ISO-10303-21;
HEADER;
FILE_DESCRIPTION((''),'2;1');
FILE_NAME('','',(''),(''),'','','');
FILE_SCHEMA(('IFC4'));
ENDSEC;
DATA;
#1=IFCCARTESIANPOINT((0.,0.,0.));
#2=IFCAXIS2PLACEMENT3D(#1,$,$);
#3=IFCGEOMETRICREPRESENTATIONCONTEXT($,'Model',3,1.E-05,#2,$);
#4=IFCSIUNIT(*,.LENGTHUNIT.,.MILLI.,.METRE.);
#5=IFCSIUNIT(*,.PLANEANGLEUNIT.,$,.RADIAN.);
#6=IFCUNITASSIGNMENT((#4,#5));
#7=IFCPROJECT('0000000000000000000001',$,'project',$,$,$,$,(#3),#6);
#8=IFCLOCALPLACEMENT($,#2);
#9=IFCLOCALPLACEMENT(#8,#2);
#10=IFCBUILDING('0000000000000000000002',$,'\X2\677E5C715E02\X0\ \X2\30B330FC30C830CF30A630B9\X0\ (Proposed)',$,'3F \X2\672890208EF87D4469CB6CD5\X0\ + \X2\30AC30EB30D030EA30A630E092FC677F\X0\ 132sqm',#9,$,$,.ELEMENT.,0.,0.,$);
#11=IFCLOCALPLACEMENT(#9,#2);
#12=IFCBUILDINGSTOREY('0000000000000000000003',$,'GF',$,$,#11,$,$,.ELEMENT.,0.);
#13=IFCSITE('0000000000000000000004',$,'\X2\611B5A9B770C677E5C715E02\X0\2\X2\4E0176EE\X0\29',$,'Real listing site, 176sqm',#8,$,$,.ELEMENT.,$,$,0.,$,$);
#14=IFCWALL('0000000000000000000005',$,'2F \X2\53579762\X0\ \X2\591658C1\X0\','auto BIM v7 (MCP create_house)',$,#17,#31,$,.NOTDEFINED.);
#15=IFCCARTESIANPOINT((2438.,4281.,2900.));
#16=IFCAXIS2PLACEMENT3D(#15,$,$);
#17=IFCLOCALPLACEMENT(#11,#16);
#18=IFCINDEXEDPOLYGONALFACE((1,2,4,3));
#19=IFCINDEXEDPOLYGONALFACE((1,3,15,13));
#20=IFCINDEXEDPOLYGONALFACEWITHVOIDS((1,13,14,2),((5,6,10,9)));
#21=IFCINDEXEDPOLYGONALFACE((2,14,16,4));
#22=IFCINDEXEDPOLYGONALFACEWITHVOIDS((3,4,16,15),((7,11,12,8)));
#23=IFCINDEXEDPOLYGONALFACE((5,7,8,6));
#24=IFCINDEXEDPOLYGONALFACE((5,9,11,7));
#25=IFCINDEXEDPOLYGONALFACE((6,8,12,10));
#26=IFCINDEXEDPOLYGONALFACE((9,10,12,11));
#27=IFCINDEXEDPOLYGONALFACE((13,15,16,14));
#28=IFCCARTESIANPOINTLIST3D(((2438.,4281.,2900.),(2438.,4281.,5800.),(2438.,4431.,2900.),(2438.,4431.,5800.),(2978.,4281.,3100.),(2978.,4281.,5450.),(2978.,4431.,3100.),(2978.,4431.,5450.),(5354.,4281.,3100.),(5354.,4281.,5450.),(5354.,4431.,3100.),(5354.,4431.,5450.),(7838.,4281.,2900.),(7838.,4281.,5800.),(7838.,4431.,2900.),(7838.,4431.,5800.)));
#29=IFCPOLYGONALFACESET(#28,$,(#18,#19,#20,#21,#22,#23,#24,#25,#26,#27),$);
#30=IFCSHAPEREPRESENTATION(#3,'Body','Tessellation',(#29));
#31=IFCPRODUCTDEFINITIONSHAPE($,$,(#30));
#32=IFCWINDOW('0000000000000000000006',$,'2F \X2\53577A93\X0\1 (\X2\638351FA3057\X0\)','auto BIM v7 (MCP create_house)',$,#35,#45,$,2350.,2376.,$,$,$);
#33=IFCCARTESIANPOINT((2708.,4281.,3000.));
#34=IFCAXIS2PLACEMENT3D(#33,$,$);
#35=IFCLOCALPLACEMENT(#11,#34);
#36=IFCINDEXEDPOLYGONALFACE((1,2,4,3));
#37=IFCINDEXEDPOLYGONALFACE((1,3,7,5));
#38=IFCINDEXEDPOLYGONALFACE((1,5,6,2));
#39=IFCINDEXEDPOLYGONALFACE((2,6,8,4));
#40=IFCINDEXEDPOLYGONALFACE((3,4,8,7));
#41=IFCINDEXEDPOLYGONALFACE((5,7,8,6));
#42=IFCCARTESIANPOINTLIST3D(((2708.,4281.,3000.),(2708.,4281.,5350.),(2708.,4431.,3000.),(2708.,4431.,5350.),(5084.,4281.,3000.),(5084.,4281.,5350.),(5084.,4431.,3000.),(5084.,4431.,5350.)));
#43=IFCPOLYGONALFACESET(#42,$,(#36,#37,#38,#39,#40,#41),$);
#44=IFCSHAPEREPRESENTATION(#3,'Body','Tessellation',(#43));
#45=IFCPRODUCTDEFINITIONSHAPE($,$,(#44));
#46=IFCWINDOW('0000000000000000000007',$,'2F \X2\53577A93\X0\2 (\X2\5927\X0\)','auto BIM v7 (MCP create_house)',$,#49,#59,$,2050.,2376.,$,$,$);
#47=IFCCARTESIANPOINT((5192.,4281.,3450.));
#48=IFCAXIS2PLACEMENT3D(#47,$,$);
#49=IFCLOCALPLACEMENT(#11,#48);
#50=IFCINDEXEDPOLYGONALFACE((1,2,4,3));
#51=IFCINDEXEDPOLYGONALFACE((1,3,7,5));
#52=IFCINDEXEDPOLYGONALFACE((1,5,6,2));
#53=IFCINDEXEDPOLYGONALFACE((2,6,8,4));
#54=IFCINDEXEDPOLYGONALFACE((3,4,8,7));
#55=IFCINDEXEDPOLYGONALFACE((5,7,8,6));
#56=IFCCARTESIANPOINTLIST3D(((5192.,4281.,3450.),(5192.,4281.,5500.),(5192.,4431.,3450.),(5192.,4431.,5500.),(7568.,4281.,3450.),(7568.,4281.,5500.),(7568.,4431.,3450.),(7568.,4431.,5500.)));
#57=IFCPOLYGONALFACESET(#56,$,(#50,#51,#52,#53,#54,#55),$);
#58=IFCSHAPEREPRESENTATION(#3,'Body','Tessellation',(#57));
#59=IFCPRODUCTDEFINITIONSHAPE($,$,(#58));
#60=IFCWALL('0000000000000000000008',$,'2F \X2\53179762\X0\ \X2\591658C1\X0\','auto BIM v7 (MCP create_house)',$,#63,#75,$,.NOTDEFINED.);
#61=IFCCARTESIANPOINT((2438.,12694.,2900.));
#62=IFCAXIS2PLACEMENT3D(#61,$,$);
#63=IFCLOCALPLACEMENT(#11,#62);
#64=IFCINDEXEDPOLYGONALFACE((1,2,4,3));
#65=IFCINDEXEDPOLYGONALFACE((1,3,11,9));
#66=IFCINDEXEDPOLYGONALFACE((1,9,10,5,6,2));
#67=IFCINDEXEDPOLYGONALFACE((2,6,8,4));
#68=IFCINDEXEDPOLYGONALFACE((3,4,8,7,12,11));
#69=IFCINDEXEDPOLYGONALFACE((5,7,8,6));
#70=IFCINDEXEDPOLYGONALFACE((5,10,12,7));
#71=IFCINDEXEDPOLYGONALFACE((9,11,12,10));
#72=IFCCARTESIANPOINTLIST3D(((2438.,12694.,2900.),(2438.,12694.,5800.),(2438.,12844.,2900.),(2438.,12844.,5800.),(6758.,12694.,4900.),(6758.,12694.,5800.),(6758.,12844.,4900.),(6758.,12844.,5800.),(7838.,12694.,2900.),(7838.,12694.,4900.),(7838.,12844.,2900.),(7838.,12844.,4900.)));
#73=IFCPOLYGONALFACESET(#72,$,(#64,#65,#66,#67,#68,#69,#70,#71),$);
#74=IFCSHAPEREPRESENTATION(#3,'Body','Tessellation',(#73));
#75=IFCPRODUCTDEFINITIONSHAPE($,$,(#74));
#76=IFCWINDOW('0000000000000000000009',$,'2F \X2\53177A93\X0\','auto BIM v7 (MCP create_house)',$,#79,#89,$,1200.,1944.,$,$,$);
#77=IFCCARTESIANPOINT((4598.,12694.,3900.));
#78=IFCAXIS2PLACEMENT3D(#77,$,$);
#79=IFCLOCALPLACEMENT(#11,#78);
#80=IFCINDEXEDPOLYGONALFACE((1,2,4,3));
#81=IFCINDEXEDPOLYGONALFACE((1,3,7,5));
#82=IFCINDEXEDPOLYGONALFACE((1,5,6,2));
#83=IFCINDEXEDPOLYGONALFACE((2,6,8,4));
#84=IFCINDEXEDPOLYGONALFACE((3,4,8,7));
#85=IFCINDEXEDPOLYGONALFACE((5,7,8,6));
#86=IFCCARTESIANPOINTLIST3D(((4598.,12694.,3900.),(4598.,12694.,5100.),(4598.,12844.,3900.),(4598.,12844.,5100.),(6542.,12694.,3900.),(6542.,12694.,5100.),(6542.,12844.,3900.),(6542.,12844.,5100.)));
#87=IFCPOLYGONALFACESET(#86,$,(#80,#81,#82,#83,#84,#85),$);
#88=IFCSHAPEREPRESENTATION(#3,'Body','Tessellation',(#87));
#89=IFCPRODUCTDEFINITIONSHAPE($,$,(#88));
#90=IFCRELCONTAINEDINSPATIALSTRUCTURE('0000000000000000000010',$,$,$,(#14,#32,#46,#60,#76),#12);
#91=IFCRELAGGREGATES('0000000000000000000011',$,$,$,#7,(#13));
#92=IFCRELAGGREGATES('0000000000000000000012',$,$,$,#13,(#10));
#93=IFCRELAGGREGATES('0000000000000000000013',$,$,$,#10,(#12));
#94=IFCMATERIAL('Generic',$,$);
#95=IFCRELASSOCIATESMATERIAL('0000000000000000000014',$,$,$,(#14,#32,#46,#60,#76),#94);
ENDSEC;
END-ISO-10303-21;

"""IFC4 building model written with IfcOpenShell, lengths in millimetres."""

from ifc_helpers import new_model, si_unit, frame, frame_2d, origin, place, context, project, spatial, rectangle, extrude, material, element, fill, save


model = new_model("IFC4")

# Units and contexts
model_context = context("Model", 3, precision=1e-05, world=origin())
ifc_project = project(units=[si_unit("LENGTHUNIT", "METRE", prefix="MILLI"), si_unit("PLANEANGLEUNIT", "RADIAN")], contexts=[model_context])

# Site, building, storey
site_placement = place(None, origin())
site = spatial("IfcSite", under=ifc_project, at=site_placement, Name="愛媛県松山市2丁目29", ObjectType="Real listing site, 176sqm", CompositionType="ELEMENT", RefElevation=0.0)
building_placement = place(site_placement, origin())
building = spatial("IfcBuilding", under=site, at=building_placement, Name="松山市 コートハウス (Proposed)", ObjectType="3F 木造軸組構法 + ガルバリウム鋼板 132sqm", CompositionType="ELEMENT", ElevationOfRefHeight=0.0, ElevationOfTerrain=0.0)
storey_placement = place(building_placement, origin())
storey = spatial("IfcBuildingStorey", under=building, at=storey_placement, Name="GF", CompositionType="ELEMENT", Elevation=0.0)

# Shared definitions
ifc_material = material(Name="Generic")

# Wall, openings, windows
wall_1_placement = place(storey_placement, frame((2438.0, 4281.0, 2900.0)))
wall_1 = element("IfcWall", 1, at=wall_1_placement, inside=storey, material=ifc_material, Name="2F 南面 外壁", Description="auto BIM v7 (MCP create_house)", PredefinedType="NOTDEFINED", context=model_context, shape_type="SweptSolid", body=[
    extrude(rectangle(XDim=5400.0, YDim=150.0, at=frame_2d((2700.0, 75.0))), frame((2438.0, 4281.0, 2900.0)), (0.0, 0.0, 1.0), 2900.0),
])
opening_1_placement = place(storey_placement, frame((2708.0, 4281.0, 3000.0)))
opening_1 = element("IfcOpeningElement", 2, at=opening_1_placement, cuts=wall_1, PredefinedType="NOTDEFINED", context=model_context, shape_type="SweptSolid", body=[
    extrude(rectangle(XDim=2376.0, YDim=150.0, at=frame_2d((1188.0, 75.0))), frame((2708.0, 4281.0, 3000.0)), (0.0, 0.0, 1.0), 2350.0),
])
opening_2_placement = place(storey_placement, frame((5192.0, 4281.0, 3450.0)))
opening_2 = element("IfcOpeningElement", 3, at=opening_2_placement, cuts=wall_1, PredefinedType="NOTDEFINED", context=model_context, shape_type="SweptSolid", body=[
    extrude(rectangle(XDim=2376.0, YDim=150.0, at=frame_2d((1188.0, 75.0))), frame((5192.0, 4281.0, 3450.0)), (0.0, 0.0, 1.0), 2050.0),
])
window_1_placement = place(storey_placement, frame((2708.0, 4281.0, 3000.0)))
window_1 = element("IfcWindow", 4, at=window_1_placement, inside=storey, material=ifc_material, Name="2F 南窓1 (掃出し)", Description="auto BIM v7 (MCP create_house)", OverallHeight=2350.0, OverallWidth=2376.0, context=model_context, shape_type="SweptSolid", body=[
    extrude(rectangle(XDim=2376.0, YDim=150.0, at=frame_2d((1188.0, 75.0))), frame((2708.0, 4281.0, 3000.0)), (0.0, 0.0, 1.0), 2350.0),
])
fill(opening_1, window_1)
window_2_placement = place(storey_placement, frame((5192.0, 4281.0, 3450.0)))
window_2 = element("IfcWindow", 5, at=window_2_placement, inside=storey, material=ifc_material, Name="2F 南窓2 (大)", Description="auto BIM v7 (MCP create_house)", OverallHeight=2050.0, OverallWidth=2376.0, context=model_context, shape_type="SweptSolid", body=[
    extrude(rectangle(XDim=2376.0, YDim=150.0, at=frame_2d((1188.0, 75.0))), frame((5192.0, 4281.0, 3450.0)), (0.0, 0.0, 1.0), 2050.0),
])
fill(opening_2, window_2)

# Wall, opening, window
wall_2_placement = place(storey_placement, frame((2438.0, 12694.0, 2900.0)))
wall_2 = element("IfcWall", 6, at=wall_2_placement, inside=storey, material=ifc_material, Name="2F 北面 外壁", Description="auto BIM v7 (MCP create_house)", PredefinedType="NOTDEFINED", context=model_context, shape_type="SweptSolid", body=[
    extrude(rectangle(XDim=5400.0, YDim=150.0, at=frame_2d((2700.0, 75.0))), frame((2438.0, 12694.0, 2900.0)), (0.0, 0.0, 1.0), 2900.0),
])
opening_3_placement = place(storey_placement, frame((4598.0, 12694.0, 3900.0)))
opening_3 = element("IfcOpeningElement", 7, at=opening_3_placement, cuts=wall_2, PredefinedType="NOTDEFINED", context=model_context, shape_type="SweptSolid", body=[
    extrude(rectangle(XDim=1944.0, YDim=150.0, at=frame_2d((972.0, 75.0))), frame((4598.0, 12694.0, 3900.0)), (0.0, 0.0, 1.0), 1200.0),
])
window_3_placement = place(storey_placement, frame((4598.0, 12694.0, 3900.0)))
window_3 = element("IfcWindow", 8, at=window_3_placement, inside=storey, material=ifc_material, Name="2F 北窓", Description="auto BIM v7 (MCP create_house)", OverallHeight=1200.0, OverallWidth=1944.0, context=model_context, shape_type="SweptSolid", body=[
    extrude(rectangle(XDim=1944.0, YDim=150.0, at=frame_2d((972.0, 75.0))), frame((4598.0, 12694.0, 3900.0)), (0.0, 0.0, 1.0), 1200.0),
])
fill(opening_3, window_3)

save(model, "model.ifc")
